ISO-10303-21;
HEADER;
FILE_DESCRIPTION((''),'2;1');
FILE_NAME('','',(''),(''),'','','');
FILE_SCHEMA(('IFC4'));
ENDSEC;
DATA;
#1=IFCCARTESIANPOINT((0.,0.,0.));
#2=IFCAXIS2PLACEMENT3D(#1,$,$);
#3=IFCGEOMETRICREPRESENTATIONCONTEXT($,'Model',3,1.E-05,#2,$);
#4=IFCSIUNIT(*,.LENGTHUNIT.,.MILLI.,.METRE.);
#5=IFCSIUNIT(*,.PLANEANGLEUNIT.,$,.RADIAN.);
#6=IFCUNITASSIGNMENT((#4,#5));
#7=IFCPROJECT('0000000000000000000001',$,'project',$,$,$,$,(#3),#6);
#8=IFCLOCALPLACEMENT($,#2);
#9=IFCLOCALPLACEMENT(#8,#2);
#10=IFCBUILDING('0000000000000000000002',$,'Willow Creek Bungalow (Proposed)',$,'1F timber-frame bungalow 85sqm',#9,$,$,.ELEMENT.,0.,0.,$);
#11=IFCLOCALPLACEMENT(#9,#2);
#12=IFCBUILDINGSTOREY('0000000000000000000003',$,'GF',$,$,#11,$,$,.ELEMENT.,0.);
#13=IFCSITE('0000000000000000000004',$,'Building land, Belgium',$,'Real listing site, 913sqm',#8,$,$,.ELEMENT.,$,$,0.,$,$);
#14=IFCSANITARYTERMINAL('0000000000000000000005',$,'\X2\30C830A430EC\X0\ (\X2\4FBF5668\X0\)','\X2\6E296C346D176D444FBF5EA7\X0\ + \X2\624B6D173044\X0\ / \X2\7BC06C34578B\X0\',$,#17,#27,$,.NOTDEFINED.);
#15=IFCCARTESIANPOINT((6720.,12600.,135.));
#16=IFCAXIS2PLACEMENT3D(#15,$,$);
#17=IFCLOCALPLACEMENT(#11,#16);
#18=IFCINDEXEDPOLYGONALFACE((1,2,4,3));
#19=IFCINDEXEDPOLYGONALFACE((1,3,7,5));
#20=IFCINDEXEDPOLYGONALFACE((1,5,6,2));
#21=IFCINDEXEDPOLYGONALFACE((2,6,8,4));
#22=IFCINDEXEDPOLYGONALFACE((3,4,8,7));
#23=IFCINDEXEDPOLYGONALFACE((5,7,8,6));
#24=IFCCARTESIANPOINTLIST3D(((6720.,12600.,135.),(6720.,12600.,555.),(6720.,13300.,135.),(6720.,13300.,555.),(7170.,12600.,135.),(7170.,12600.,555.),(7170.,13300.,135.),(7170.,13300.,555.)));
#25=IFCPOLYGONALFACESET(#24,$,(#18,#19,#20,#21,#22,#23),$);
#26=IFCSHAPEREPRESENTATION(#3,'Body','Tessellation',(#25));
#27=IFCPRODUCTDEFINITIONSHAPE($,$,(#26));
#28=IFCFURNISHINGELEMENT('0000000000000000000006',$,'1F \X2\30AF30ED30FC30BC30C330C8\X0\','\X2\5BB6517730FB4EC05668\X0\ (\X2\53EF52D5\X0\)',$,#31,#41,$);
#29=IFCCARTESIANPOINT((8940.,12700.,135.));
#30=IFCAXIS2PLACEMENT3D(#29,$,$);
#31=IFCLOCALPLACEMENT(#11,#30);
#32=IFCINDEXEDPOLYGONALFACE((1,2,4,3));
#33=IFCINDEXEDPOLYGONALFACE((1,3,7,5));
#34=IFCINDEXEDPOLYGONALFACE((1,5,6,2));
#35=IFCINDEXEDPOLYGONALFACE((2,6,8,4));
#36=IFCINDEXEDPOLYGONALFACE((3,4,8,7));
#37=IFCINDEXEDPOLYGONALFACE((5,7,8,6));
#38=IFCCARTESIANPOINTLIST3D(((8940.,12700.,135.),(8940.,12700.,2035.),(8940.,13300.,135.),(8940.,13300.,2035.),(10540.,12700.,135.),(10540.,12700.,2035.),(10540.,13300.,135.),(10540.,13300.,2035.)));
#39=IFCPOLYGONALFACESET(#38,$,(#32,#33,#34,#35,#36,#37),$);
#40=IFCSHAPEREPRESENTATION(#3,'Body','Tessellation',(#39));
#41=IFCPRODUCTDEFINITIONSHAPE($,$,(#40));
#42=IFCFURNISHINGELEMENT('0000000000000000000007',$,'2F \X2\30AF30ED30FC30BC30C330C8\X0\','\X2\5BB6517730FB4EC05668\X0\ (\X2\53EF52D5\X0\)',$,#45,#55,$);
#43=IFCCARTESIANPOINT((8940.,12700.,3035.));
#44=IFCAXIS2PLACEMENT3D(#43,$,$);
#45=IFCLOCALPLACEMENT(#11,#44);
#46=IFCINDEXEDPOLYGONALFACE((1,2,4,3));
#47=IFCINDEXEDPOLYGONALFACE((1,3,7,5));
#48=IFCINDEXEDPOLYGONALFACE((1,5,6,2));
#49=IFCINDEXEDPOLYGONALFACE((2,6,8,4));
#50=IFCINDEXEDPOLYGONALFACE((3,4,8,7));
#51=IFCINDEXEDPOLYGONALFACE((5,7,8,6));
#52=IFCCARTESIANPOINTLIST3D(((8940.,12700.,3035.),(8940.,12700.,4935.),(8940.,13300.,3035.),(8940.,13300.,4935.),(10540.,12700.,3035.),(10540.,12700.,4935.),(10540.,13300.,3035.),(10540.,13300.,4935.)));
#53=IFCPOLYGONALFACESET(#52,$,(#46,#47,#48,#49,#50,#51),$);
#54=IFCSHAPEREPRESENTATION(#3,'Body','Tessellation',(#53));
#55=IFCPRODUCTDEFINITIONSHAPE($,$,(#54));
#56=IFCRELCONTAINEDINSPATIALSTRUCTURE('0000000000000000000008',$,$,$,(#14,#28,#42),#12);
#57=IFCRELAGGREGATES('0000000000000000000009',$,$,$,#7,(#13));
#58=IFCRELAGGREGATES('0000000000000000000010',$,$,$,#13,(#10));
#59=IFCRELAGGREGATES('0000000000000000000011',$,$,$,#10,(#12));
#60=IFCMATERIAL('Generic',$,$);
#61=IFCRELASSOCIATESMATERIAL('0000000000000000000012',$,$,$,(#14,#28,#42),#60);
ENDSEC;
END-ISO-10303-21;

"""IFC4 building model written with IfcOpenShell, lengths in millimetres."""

from ifc_helpers import new_model, si_unit, frame, frame_2d, origin, place, context, project, spatial, rectangle, extrude, material, element, save


model = new_model("IFC4")

# Units and contexts
model_context = context("Model", 3, precision=1e-05, world=origin())
ifc_project = project(units=[si_unit("LENGTHUNIT", "METRE", prefix="MILLI"), si_unit("PLANEANGLEUNIT", "RADIAN")], contexts=[model_context])

# Site, building, storey
site_placement = place(None, origin())
site = spatial("IfcSite", under=ifc_project, at=site_placement, Name="Building land, Belgium", ObjectType="Real listing site, 913sqm", CompositionType="ELEMENT", RefElevation=0.0)
building_placement = place(site_placement, origin())
building = spatial("IfcBuilding", under=site, at=building_placement, Name="Willow Creek Bungalow (Proposed)", ObjectType="1F timber-frame bungalow 85sqm", CompositionType="ELEMENT", ElevationOfRefHeight=0.0, ElevationOfTerrain=0.0)
storey_placement = place(building_placement, origin())
storey = spatial("IfcBuildingStorey", under=building, at=storey_placement, Name="GF", CompositionType="ELEMENT", Elevation=0.0)

# Sanitary terminal
ifc_material_1 = material(Name="Generic")
sanitary_terminal_1_placement = place(storey_placement, frame((6720.0, 12600.0, 135.0)))
element("IfcSanitaryTerminal", 1, at=sanitary_terminal_1_placement, inside=storey, material=ifc_material_1, Name="トイレ (便器)", Description="温水洗浄便座 + 手洗い / 節水型", PredefinedType="NOTDEFINED", context=model_context, shape_type="SweptSolid", body=[
    extrude(rectangle(XDim=450.0, YDim=700.0, at=frame_2d((225.0, 350.0))), frame((6720.0, 12600.0, 135.0)), (0.0, 0.0, 1.0), 420.0),
])

# Furnishing elements
furnishing_1_placement = place(storey_placement, frame((8940.0, 12700.0, 135.0)))
element("IfcFurnishingElement", 2, at=furnishing_1_placement, inside=storey, material=ifc_material_1, Name="1F クローゼット", Description="家具・什器 (可動)", context=model_context, shape_type="SweptSolid", body=[
    extrude(rectangle(XDim=1600.0, YDim=600.0, at=frame_2d((800.0, 300.0))), frame((8940.0, 12700.0, 135.0)), (0.0, 0.0, 1.0), 1900.0),
])
furnishing_2_placement = place(storey_placement, frame((8940.0, 12700.0, 3035.0)))
element("IfcFurnishingElement", 3, at=furnishing_2_placement, inside=storey, material=ifc_material_1, Name="2F クローゼット", Description="家具・什器 (可動)", context=model_context, shape_type="SweptSolid", body=[
    extrude(rectangle(XDim=1600.0, YDim=600.0, at=frame_2d((800.0, 300.0))), frame((8940.0, 12700.0, 3035.0)), (0.0, 0.0, 1.0), 1900.0),
])

save(model, "model.ifc")
